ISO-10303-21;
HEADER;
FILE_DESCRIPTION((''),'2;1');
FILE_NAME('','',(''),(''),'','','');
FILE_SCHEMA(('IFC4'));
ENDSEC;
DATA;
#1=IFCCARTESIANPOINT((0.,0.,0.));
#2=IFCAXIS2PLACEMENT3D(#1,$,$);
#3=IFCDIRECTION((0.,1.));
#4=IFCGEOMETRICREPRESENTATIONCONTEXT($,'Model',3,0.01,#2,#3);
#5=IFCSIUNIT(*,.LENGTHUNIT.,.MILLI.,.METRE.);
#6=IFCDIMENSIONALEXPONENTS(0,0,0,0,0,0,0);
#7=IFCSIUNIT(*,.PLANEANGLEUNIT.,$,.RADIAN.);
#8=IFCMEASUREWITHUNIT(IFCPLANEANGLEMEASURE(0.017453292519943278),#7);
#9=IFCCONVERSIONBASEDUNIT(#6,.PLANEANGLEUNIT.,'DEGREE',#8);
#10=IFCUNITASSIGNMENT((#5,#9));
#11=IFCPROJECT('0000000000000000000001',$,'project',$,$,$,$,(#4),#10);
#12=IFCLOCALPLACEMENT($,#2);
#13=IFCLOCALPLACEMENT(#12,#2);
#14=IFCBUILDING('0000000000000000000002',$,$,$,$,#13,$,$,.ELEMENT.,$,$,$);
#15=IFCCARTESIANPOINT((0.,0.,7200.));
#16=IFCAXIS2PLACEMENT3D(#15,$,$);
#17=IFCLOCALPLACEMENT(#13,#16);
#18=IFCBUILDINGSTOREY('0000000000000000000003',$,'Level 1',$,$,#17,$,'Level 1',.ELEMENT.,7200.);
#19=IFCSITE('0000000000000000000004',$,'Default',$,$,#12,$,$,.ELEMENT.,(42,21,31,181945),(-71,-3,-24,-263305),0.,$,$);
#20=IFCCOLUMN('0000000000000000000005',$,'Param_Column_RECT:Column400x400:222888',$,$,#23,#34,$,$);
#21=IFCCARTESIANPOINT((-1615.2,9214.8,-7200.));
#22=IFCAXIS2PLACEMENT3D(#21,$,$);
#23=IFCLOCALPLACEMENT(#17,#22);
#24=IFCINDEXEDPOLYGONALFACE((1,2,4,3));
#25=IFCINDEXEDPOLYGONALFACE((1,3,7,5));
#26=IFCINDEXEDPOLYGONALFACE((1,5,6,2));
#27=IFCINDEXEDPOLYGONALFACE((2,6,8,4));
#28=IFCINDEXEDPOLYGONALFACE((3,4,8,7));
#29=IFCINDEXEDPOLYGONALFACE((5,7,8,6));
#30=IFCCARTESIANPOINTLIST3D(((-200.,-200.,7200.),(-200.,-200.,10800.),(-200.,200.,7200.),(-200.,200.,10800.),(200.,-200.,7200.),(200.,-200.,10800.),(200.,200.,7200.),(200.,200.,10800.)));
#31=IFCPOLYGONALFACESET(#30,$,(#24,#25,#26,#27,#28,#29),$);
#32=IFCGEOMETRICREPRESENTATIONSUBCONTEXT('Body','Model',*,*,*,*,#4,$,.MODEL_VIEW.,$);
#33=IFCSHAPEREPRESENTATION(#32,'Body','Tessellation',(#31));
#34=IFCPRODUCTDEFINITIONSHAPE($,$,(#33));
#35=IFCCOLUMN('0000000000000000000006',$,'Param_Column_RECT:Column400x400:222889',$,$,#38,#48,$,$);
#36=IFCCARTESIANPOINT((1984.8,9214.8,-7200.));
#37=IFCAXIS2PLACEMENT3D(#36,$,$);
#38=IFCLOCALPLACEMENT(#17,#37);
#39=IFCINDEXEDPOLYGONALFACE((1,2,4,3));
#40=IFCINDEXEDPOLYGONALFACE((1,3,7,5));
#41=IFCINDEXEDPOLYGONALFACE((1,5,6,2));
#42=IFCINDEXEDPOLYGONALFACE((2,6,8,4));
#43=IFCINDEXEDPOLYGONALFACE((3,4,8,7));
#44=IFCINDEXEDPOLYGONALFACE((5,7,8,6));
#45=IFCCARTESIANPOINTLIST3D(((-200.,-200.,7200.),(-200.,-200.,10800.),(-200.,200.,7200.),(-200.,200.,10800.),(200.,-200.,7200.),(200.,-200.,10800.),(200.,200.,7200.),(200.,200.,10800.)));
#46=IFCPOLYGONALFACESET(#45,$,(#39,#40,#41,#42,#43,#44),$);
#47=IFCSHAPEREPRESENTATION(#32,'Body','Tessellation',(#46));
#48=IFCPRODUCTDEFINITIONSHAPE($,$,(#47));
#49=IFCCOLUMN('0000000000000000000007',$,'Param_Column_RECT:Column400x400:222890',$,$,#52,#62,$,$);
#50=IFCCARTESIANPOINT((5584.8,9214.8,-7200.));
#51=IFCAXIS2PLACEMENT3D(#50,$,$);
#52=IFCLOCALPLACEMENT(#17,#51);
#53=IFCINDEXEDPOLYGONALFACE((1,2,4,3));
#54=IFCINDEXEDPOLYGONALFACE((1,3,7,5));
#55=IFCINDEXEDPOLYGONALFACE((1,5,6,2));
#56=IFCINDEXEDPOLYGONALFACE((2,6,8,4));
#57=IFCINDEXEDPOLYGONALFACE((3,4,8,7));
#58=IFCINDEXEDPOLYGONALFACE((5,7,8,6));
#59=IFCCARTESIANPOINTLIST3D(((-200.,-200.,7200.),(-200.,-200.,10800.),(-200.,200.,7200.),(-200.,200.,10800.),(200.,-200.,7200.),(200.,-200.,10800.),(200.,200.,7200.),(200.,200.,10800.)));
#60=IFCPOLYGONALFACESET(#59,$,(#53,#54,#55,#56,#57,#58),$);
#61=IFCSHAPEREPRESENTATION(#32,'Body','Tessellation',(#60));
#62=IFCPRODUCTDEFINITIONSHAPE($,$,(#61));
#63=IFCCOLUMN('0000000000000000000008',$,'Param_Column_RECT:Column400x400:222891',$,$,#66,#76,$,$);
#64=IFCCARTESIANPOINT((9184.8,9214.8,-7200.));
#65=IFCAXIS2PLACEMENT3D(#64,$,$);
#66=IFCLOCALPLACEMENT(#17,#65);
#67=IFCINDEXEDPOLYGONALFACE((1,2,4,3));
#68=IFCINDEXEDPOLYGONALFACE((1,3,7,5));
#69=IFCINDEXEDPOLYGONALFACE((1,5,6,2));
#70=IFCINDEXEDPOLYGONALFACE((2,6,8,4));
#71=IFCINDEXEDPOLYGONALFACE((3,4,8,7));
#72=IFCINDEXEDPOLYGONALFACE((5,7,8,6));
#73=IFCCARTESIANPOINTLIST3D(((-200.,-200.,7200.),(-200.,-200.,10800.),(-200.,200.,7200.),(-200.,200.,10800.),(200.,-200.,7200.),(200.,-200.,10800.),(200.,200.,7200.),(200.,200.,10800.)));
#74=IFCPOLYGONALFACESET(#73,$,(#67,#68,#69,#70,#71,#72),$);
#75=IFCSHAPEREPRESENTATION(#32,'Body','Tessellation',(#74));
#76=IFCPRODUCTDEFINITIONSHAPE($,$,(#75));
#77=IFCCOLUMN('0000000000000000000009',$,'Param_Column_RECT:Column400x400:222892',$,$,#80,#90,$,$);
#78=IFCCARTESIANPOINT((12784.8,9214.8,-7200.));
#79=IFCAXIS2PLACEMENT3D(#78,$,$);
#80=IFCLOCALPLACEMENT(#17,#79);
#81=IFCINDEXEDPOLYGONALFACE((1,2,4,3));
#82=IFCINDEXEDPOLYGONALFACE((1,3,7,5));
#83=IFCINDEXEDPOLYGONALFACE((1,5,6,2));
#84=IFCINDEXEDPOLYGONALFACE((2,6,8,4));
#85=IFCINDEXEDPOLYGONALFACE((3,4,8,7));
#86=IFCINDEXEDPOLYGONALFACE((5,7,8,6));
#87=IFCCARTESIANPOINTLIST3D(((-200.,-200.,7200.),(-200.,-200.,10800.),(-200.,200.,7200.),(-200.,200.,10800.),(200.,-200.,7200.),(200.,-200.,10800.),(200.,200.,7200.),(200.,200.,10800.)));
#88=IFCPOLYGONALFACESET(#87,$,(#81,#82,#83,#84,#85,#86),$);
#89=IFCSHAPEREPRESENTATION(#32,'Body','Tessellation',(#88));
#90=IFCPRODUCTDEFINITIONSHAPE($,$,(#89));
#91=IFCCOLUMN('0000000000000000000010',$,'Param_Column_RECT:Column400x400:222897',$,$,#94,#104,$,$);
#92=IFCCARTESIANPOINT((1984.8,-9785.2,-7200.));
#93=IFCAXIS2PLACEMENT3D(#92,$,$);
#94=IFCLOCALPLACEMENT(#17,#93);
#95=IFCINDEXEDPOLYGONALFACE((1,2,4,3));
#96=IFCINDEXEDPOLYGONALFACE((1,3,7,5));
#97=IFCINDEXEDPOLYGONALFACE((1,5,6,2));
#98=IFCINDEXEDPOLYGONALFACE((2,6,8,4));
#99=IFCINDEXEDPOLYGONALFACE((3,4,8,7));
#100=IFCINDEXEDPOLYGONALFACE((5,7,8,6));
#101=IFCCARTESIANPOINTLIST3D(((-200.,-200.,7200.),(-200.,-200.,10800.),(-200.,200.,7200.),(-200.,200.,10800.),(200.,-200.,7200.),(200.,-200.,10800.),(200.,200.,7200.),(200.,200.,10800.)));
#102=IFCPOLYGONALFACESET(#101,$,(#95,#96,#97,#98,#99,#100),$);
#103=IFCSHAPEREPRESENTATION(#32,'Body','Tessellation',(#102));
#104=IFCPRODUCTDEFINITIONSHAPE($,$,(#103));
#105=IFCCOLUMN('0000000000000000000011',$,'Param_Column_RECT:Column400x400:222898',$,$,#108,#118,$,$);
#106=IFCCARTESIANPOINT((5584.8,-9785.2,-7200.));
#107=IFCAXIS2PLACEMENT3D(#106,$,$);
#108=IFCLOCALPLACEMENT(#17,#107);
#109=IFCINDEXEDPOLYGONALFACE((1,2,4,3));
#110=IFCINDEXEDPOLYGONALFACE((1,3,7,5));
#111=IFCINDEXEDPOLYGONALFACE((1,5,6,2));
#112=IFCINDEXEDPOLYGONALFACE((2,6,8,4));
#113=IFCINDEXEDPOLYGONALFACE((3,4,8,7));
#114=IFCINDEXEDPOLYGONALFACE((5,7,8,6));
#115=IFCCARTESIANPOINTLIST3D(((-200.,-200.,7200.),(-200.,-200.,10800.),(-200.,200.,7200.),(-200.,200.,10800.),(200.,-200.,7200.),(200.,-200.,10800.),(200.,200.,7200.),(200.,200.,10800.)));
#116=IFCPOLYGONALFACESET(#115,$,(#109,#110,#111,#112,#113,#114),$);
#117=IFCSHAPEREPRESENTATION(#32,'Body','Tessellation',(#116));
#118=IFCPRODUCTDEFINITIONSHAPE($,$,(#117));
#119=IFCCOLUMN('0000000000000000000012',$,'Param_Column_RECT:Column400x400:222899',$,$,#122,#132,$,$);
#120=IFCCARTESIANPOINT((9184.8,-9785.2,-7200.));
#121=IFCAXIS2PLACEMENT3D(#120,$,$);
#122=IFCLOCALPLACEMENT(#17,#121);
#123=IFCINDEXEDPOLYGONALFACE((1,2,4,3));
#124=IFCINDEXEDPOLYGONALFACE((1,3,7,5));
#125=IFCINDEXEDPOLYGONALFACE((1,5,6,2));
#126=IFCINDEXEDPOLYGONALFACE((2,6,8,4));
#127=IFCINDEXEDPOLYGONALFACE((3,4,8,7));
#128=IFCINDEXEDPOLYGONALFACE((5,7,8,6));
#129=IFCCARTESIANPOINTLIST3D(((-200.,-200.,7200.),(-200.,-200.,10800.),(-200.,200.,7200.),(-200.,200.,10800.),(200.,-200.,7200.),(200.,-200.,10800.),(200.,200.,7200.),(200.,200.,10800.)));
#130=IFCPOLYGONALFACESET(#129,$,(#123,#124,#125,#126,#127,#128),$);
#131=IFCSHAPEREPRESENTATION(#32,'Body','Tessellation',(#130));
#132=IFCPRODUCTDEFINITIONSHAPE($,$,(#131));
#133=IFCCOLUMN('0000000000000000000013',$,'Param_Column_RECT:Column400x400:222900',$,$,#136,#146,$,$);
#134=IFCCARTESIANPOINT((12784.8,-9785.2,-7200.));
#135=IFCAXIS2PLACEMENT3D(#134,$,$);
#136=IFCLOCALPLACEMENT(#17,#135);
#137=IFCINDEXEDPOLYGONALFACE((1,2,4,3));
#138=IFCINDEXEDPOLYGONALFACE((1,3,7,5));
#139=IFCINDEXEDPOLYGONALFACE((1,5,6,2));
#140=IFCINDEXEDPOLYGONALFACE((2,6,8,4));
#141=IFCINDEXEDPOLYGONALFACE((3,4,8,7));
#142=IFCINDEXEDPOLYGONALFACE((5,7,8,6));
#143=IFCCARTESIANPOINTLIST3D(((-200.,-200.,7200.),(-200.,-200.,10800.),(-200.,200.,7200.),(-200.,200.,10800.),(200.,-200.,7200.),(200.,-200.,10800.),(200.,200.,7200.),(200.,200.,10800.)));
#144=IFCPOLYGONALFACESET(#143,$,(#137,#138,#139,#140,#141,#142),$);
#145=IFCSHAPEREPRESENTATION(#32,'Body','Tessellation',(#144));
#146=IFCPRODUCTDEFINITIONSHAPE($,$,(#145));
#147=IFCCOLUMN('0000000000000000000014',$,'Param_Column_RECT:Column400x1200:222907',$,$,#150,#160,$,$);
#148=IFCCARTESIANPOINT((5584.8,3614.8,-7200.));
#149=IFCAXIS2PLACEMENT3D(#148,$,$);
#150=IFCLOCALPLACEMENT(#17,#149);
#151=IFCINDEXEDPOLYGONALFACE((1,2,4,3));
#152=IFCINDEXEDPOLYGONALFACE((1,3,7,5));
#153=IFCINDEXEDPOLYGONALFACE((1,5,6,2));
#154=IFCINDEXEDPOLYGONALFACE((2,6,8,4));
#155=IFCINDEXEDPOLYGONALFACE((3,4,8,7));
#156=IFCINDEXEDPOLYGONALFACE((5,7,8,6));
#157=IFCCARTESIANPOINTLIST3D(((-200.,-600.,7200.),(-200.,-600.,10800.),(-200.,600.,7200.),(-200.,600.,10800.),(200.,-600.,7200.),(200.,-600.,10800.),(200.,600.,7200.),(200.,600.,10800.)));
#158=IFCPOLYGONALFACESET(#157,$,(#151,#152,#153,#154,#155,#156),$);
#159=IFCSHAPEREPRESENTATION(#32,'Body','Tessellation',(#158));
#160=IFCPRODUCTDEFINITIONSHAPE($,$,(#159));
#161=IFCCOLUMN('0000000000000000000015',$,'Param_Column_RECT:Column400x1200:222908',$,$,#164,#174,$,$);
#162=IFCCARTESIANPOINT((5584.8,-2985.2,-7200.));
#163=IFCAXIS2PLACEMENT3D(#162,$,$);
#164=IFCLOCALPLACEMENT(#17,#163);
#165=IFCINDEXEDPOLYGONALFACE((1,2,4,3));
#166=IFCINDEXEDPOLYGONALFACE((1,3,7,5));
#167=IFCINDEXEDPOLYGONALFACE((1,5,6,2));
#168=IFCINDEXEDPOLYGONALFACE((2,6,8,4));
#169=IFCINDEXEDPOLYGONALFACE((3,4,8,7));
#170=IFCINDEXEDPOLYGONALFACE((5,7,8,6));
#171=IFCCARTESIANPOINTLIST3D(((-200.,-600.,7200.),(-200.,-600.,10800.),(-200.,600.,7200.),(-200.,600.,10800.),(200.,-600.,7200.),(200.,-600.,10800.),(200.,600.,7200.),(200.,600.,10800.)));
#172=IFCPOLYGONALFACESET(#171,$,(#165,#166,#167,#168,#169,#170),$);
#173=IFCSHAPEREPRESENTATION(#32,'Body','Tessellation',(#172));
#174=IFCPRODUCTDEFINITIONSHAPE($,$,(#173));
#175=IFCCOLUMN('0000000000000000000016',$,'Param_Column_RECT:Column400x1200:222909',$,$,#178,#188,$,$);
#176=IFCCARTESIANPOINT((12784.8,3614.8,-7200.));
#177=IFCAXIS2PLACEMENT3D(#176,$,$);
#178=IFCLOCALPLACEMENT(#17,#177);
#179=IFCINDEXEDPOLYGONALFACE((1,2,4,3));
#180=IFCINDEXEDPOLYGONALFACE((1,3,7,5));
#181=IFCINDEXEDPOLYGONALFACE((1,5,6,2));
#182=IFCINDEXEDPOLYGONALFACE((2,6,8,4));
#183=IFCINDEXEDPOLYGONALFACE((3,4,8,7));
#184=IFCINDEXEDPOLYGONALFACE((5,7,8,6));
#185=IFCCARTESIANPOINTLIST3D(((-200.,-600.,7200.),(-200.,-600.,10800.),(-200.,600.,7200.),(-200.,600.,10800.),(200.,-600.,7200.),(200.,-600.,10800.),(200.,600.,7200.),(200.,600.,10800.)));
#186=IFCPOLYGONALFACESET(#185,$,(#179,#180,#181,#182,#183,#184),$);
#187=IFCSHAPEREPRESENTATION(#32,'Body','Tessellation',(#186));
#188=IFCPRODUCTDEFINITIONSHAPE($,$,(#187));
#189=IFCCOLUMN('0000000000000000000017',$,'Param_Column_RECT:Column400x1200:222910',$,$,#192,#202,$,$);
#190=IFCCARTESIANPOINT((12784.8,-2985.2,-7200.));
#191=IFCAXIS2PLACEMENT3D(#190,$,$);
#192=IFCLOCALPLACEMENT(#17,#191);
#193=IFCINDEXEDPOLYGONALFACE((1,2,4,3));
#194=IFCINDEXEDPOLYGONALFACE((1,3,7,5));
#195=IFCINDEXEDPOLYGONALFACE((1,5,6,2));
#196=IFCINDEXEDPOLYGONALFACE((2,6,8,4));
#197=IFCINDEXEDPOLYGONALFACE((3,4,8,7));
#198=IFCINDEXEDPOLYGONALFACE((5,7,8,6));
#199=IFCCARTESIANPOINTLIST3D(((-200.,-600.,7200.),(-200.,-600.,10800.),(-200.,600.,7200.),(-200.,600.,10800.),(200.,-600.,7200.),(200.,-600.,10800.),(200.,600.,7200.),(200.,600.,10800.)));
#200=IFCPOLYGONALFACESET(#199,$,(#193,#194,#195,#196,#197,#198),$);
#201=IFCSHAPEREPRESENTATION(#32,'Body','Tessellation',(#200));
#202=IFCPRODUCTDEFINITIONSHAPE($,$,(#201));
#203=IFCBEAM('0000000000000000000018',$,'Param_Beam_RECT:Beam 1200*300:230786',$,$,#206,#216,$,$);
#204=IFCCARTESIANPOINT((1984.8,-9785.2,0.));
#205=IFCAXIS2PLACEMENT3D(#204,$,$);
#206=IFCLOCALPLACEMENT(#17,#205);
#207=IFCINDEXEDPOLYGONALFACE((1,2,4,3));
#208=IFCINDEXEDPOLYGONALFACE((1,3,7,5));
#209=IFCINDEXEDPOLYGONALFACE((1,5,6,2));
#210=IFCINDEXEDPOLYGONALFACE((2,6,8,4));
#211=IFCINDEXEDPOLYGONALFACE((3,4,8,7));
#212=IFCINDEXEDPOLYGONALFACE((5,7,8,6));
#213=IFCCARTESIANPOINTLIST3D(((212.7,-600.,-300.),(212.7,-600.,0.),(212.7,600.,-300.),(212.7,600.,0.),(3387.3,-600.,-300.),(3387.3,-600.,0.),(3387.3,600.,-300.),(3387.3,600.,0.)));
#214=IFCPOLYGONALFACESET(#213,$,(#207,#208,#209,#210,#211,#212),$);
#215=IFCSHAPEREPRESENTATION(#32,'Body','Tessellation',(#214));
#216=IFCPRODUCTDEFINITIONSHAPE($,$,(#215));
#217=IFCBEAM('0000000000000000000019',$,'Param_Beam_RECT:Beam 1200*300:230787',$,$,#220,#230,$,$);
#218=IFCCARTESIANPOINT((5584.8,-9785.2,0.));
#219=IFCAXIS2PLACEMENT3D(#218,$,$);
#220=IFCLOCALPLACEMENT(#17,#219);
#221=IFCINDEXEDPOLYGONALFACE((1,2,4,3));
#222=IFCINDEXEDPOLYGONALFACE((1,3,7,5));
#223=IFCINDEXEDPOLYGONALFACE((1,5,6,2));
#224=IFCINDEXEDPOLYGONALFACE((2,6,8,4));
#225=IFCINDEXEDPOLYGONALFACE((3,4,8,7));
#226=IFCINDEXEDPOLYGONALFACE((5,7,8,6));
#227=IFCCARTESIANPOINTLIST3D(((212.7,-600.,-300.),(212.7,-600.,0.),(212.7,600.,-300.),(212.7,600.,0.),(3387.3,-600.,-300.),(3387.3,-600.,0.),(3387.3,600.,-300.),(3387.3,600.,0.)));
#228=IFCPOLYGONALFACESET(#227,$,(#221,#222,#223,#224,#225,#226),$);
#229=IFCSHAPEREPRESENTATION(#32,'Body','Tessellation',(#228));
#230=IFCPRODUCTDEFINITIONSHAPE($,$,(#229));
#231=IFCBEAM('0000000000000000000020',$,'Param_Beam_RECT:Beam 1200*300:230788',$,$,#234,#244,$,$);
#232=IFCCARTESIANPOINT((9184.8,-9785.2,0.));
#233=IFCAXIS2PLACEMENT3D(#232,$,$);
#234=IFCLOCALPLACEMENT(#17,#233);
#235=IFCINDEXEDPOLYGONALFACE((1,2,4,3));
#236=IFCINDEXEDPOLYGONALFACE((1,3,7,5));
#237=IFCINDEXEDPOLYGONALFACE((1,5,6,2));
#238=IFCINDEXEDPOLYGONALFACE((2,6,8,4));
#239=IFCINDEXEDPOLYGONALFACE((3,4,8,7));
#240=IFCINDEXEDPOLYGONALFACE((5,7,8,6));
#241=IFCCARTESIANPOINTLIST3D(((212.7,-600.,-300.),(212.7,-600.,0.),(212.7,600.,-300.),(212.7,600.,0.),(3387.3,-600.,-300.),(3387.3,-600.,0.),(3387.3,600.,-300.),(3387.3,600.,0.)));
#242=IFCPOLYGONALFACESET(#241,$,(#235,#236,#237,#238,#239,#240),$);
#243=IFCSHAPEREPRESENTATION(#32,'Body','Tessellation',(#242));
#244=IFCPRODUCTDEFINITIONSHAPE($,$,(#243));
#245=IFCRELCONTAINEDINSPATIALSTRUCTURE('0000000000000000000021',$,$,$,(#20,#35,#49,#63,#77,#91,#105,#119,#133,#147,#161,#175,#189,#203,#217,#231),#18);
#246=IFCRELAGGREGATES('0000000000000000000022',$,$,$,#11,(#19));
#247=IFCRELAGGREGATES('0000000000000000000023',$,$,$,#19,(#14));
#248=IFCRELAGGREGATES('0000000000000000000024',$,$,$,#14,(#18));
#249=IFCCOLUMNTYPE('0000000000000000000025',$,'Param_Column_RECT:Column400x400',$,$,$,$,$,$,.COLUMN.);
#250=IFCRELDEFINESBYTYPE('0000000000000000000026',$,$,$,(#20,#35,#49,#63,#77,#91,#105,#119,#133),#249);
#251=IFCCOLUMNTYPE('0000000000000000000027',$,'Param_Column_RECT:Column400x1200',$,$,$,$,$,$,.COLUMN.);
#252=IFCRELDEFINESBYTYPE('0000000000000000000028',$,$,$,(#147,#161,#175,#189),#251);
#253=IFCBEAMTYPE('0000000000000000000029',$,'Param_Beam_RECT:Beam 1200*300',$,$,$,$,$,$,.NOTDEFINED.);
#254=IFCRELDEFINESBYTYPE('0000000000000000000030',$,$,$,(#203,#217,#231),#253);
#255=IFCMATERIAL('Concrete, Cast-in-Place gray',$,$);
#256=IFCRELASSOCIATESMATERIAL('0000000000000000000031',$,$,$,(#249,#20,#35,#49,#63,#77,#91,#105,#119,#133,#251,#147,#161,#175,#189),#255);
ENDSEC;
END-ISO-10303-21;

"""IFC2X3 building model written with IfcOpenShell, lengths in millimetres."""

from ifc_helpers import new_model, entity, si_unit, converted_unit, direction, frame, frame_2d, origin, origin_2d_with_axis, place, context, subcontext, project, spatial, rectangle, extrude, source, transform, mapped, material, type_object, type_shapes, element, save


model = new_model("IFC2X3")

# Units and contexts
model_context = context("Model", 3, precision=0.01, world=origin(), true_north=direction((0.0, 1.0)))
body_context = subcontext(model_context, "Body", "Model", "MODEL_VIEW")
ifc_project = project(units=[si_unit("LENGTHUNIT", "METRE", prefix="MILLI"), converted_unit("PLANEANGLEUNIT", "DEGREE", entity("IfcPlaneAngleMeasure", 0.017453292519943278), si_unit("PLANEANGLEUNIT", "RADIAN"), dimensions=[0, 0, 0, 0, 0, 0, 0])], contexts=[model_context])

# Site, building, storey
site_placement = place(None, origin())
site = spatial("IfcSite", under=ifc_project, at=site_placement, Name="Default", CompositionType="ELEMENT", RefLatitude=(42, 21, 31, 181945), RefLongitude=(-71, -3, -24, -263305), RefElevation=0.0)
building_placement = place(site_placement, origin())
building = spatial("IfcBuilding", under=site, at=building_placement, CompositionType="ELEMENT")
storey_placement = place(building_placement, frame((0.0, 0.0, 7200.0)))
storey = spatial("IfcBuildingStorey", under=building, at=storey_placement, Name="Level 1", LongName="Level 1", CompositionType="ELEMENT", Elevation=7200.0)

# Columns
ifc_material_1 = material(Name="Concrete, Cast-in-Place gray")
column_type_1 = type_object("IfcColumnType", Name="Param_Column_RECT:Column400x400", PredefinedType="COLUMN", material=ifc_material_1)
shared_shape_1 = source(origin(), body_context, "Body", "SweptSolid", [
    extrude(rectangle(XDim=400.0, YDim=400.0, at=origin_2d_with_axis()), frame((0.0, 0.0, 7200.0), z_axis=(0.0, 0.0, 1.0), x_axis=(-1.0, 0.0, 0.0)), (0.0, 0.0, 1.0), 3600.0),
])
type_shapes(column_type_1, [shared_shape_1])
for number, where, name in (
    (1, (-1615.2, 9214.8, -7200.0), "Param_Column_RECT:Column400x400:222888"),
    (2, (1984.8, 9214.8, -7200.0), "Param_Column_RECT:Column400x400:222889"),
    (3, (5584.8, 9214.8, -7200.0), "Param_Column_RECT:Column400x400:222890"),
    (4, (9184.8, 9214.8, -7200.0), "Param_Column_RECT:Column400x400:222891"),
    (5, (12784.8, 9214.8, -7200.0), "Param_Column_RECT:Column400x400:222892"),
    (6, (1984.8, -9785.2, -7200.0), "Param_Column_RECT:Column400x400:222897"),
    (7, (5584.8, -9785.2, -7200.0), "Param_Column_RECT:Column400x400:222898"),
    (8, (9184.8, -9785.2, -7200.0), "Param_Column_RECT:Column400x400:222899"),
    (9, (12784.8, -9785.2, -7200.0), "Param_Column_RECT:Column400x400:222900"),
):
    element("IfcColumn", number, at=place(storey_placement, frame(where)), inside=storey, type_object=column_type_1, material=ifc_material_1, Name=name, context=body_context, shape_type="MappedRepresentation", body=[
        mapped(shared_shape_1, transform((0.0, 0.0, 0.0), scale=1.0)),
    ])
column_type_2 = type_object("IfcColumnType", Name="Param_Column_RECT:Column400x1200", PredefinedType="COLUMN", material=ifc_material_1)
shared_shape_2 = source(origin(), body_context, "Body", "SweptSolid", [
    extrude(rectangle(XDim=400.0, YDim=1200.0, at=origin_2d_with_axis()), frame((0.0, 0.0, 7200.0), z_axis=(0.0, 0.0, 1.0), x_axis=(-1.0, 0.0, 0.0)), (0.0, 0.0, 1.0), 3600.0),
])
type_shapes(column_type_2, [shared_shape_2])
for number, where, name in (
    (10, (5584.8, 3614.8, -7200.0), "Param_Column_RECT:Column400x1200:222907"),
    (11, (5584.8, -2985.2, -7200.0), "Param_Column_RECT:Column400x1200:222908"),
    (12, (12784.8, 3614.8, -7200.0), "Param_Column_RECT:Column400x1200:222909"),
    (13, (12784.8, -2985.2, -7200.0), "Param_Column_RECT:Column400x1200:222910"),
):
    element("IfcColumn", number, at=place(storey_placement, frame(where)), inside=storey, type_object=column_type_2, material=ifc_material_1, Name=name, context=body_context, shape_type="MappedRepresentation", body=[
        mapped(shared_shape_2, transform((0.0, 0.0, 0.0), scale=1.0)),
    ])

# Beams
beam_type_1 = type_object("IfcBeamType", Name="Param_Beam_RECT:Beam 1200*300", PredefinedType="NOTDEFINED")
beam_1_placement = place(storey_placement, frame((1984.8, -9785.2, 0.0)))
element("IfcBeam", 14, at=beam_1_placement, inside=storey, type_object=beam_type_1, Name="Param_Beam_RECT:Beam 1200*300:230786", context=body_context, shape_type="SweptSolid", body=[
    extrude(rectangle(XDim=300.0, YDim=1200.0, at=origin_2d_with_axis()), frame((212.7, 0.0, -150.0), z_axis=(1.0, 0.0, 0.0), x_axis=(0.0, 0.0, -1.0)), (0.0, 0.0, 1.0), 3174.6),
])
for number, where, name in (
    (15, (5584.8, -9785.2, 0.0), "Param_Beam_RECT:Beam 1200*300:230787"),
    (16, (9184.8, -9785.2, 0.0), "Param_Beam_RECT:Beam 1200*300:230788"),
):
    element("IfcBeam", number, at=place(storey_placement, frame(where)), inside=storey, type_object=beam_type_1, Name=name, context=body_context, shape_type="SweptSolid", body=[
        extrude(rectangle(XDim=300.0, YDim=1200.0, at=frame_2d((0.0, 0.0), x_axis=(1.0, 0.0))), frame((212.7, 0.0, -150.0), z_axis=(1.0, 0.0, 0.0), x_axis=(0.0, 0.0, -1.0)), (0.0, 0.0, 1.0), 3174.6),
    ])

save(model, "model.ifc")
